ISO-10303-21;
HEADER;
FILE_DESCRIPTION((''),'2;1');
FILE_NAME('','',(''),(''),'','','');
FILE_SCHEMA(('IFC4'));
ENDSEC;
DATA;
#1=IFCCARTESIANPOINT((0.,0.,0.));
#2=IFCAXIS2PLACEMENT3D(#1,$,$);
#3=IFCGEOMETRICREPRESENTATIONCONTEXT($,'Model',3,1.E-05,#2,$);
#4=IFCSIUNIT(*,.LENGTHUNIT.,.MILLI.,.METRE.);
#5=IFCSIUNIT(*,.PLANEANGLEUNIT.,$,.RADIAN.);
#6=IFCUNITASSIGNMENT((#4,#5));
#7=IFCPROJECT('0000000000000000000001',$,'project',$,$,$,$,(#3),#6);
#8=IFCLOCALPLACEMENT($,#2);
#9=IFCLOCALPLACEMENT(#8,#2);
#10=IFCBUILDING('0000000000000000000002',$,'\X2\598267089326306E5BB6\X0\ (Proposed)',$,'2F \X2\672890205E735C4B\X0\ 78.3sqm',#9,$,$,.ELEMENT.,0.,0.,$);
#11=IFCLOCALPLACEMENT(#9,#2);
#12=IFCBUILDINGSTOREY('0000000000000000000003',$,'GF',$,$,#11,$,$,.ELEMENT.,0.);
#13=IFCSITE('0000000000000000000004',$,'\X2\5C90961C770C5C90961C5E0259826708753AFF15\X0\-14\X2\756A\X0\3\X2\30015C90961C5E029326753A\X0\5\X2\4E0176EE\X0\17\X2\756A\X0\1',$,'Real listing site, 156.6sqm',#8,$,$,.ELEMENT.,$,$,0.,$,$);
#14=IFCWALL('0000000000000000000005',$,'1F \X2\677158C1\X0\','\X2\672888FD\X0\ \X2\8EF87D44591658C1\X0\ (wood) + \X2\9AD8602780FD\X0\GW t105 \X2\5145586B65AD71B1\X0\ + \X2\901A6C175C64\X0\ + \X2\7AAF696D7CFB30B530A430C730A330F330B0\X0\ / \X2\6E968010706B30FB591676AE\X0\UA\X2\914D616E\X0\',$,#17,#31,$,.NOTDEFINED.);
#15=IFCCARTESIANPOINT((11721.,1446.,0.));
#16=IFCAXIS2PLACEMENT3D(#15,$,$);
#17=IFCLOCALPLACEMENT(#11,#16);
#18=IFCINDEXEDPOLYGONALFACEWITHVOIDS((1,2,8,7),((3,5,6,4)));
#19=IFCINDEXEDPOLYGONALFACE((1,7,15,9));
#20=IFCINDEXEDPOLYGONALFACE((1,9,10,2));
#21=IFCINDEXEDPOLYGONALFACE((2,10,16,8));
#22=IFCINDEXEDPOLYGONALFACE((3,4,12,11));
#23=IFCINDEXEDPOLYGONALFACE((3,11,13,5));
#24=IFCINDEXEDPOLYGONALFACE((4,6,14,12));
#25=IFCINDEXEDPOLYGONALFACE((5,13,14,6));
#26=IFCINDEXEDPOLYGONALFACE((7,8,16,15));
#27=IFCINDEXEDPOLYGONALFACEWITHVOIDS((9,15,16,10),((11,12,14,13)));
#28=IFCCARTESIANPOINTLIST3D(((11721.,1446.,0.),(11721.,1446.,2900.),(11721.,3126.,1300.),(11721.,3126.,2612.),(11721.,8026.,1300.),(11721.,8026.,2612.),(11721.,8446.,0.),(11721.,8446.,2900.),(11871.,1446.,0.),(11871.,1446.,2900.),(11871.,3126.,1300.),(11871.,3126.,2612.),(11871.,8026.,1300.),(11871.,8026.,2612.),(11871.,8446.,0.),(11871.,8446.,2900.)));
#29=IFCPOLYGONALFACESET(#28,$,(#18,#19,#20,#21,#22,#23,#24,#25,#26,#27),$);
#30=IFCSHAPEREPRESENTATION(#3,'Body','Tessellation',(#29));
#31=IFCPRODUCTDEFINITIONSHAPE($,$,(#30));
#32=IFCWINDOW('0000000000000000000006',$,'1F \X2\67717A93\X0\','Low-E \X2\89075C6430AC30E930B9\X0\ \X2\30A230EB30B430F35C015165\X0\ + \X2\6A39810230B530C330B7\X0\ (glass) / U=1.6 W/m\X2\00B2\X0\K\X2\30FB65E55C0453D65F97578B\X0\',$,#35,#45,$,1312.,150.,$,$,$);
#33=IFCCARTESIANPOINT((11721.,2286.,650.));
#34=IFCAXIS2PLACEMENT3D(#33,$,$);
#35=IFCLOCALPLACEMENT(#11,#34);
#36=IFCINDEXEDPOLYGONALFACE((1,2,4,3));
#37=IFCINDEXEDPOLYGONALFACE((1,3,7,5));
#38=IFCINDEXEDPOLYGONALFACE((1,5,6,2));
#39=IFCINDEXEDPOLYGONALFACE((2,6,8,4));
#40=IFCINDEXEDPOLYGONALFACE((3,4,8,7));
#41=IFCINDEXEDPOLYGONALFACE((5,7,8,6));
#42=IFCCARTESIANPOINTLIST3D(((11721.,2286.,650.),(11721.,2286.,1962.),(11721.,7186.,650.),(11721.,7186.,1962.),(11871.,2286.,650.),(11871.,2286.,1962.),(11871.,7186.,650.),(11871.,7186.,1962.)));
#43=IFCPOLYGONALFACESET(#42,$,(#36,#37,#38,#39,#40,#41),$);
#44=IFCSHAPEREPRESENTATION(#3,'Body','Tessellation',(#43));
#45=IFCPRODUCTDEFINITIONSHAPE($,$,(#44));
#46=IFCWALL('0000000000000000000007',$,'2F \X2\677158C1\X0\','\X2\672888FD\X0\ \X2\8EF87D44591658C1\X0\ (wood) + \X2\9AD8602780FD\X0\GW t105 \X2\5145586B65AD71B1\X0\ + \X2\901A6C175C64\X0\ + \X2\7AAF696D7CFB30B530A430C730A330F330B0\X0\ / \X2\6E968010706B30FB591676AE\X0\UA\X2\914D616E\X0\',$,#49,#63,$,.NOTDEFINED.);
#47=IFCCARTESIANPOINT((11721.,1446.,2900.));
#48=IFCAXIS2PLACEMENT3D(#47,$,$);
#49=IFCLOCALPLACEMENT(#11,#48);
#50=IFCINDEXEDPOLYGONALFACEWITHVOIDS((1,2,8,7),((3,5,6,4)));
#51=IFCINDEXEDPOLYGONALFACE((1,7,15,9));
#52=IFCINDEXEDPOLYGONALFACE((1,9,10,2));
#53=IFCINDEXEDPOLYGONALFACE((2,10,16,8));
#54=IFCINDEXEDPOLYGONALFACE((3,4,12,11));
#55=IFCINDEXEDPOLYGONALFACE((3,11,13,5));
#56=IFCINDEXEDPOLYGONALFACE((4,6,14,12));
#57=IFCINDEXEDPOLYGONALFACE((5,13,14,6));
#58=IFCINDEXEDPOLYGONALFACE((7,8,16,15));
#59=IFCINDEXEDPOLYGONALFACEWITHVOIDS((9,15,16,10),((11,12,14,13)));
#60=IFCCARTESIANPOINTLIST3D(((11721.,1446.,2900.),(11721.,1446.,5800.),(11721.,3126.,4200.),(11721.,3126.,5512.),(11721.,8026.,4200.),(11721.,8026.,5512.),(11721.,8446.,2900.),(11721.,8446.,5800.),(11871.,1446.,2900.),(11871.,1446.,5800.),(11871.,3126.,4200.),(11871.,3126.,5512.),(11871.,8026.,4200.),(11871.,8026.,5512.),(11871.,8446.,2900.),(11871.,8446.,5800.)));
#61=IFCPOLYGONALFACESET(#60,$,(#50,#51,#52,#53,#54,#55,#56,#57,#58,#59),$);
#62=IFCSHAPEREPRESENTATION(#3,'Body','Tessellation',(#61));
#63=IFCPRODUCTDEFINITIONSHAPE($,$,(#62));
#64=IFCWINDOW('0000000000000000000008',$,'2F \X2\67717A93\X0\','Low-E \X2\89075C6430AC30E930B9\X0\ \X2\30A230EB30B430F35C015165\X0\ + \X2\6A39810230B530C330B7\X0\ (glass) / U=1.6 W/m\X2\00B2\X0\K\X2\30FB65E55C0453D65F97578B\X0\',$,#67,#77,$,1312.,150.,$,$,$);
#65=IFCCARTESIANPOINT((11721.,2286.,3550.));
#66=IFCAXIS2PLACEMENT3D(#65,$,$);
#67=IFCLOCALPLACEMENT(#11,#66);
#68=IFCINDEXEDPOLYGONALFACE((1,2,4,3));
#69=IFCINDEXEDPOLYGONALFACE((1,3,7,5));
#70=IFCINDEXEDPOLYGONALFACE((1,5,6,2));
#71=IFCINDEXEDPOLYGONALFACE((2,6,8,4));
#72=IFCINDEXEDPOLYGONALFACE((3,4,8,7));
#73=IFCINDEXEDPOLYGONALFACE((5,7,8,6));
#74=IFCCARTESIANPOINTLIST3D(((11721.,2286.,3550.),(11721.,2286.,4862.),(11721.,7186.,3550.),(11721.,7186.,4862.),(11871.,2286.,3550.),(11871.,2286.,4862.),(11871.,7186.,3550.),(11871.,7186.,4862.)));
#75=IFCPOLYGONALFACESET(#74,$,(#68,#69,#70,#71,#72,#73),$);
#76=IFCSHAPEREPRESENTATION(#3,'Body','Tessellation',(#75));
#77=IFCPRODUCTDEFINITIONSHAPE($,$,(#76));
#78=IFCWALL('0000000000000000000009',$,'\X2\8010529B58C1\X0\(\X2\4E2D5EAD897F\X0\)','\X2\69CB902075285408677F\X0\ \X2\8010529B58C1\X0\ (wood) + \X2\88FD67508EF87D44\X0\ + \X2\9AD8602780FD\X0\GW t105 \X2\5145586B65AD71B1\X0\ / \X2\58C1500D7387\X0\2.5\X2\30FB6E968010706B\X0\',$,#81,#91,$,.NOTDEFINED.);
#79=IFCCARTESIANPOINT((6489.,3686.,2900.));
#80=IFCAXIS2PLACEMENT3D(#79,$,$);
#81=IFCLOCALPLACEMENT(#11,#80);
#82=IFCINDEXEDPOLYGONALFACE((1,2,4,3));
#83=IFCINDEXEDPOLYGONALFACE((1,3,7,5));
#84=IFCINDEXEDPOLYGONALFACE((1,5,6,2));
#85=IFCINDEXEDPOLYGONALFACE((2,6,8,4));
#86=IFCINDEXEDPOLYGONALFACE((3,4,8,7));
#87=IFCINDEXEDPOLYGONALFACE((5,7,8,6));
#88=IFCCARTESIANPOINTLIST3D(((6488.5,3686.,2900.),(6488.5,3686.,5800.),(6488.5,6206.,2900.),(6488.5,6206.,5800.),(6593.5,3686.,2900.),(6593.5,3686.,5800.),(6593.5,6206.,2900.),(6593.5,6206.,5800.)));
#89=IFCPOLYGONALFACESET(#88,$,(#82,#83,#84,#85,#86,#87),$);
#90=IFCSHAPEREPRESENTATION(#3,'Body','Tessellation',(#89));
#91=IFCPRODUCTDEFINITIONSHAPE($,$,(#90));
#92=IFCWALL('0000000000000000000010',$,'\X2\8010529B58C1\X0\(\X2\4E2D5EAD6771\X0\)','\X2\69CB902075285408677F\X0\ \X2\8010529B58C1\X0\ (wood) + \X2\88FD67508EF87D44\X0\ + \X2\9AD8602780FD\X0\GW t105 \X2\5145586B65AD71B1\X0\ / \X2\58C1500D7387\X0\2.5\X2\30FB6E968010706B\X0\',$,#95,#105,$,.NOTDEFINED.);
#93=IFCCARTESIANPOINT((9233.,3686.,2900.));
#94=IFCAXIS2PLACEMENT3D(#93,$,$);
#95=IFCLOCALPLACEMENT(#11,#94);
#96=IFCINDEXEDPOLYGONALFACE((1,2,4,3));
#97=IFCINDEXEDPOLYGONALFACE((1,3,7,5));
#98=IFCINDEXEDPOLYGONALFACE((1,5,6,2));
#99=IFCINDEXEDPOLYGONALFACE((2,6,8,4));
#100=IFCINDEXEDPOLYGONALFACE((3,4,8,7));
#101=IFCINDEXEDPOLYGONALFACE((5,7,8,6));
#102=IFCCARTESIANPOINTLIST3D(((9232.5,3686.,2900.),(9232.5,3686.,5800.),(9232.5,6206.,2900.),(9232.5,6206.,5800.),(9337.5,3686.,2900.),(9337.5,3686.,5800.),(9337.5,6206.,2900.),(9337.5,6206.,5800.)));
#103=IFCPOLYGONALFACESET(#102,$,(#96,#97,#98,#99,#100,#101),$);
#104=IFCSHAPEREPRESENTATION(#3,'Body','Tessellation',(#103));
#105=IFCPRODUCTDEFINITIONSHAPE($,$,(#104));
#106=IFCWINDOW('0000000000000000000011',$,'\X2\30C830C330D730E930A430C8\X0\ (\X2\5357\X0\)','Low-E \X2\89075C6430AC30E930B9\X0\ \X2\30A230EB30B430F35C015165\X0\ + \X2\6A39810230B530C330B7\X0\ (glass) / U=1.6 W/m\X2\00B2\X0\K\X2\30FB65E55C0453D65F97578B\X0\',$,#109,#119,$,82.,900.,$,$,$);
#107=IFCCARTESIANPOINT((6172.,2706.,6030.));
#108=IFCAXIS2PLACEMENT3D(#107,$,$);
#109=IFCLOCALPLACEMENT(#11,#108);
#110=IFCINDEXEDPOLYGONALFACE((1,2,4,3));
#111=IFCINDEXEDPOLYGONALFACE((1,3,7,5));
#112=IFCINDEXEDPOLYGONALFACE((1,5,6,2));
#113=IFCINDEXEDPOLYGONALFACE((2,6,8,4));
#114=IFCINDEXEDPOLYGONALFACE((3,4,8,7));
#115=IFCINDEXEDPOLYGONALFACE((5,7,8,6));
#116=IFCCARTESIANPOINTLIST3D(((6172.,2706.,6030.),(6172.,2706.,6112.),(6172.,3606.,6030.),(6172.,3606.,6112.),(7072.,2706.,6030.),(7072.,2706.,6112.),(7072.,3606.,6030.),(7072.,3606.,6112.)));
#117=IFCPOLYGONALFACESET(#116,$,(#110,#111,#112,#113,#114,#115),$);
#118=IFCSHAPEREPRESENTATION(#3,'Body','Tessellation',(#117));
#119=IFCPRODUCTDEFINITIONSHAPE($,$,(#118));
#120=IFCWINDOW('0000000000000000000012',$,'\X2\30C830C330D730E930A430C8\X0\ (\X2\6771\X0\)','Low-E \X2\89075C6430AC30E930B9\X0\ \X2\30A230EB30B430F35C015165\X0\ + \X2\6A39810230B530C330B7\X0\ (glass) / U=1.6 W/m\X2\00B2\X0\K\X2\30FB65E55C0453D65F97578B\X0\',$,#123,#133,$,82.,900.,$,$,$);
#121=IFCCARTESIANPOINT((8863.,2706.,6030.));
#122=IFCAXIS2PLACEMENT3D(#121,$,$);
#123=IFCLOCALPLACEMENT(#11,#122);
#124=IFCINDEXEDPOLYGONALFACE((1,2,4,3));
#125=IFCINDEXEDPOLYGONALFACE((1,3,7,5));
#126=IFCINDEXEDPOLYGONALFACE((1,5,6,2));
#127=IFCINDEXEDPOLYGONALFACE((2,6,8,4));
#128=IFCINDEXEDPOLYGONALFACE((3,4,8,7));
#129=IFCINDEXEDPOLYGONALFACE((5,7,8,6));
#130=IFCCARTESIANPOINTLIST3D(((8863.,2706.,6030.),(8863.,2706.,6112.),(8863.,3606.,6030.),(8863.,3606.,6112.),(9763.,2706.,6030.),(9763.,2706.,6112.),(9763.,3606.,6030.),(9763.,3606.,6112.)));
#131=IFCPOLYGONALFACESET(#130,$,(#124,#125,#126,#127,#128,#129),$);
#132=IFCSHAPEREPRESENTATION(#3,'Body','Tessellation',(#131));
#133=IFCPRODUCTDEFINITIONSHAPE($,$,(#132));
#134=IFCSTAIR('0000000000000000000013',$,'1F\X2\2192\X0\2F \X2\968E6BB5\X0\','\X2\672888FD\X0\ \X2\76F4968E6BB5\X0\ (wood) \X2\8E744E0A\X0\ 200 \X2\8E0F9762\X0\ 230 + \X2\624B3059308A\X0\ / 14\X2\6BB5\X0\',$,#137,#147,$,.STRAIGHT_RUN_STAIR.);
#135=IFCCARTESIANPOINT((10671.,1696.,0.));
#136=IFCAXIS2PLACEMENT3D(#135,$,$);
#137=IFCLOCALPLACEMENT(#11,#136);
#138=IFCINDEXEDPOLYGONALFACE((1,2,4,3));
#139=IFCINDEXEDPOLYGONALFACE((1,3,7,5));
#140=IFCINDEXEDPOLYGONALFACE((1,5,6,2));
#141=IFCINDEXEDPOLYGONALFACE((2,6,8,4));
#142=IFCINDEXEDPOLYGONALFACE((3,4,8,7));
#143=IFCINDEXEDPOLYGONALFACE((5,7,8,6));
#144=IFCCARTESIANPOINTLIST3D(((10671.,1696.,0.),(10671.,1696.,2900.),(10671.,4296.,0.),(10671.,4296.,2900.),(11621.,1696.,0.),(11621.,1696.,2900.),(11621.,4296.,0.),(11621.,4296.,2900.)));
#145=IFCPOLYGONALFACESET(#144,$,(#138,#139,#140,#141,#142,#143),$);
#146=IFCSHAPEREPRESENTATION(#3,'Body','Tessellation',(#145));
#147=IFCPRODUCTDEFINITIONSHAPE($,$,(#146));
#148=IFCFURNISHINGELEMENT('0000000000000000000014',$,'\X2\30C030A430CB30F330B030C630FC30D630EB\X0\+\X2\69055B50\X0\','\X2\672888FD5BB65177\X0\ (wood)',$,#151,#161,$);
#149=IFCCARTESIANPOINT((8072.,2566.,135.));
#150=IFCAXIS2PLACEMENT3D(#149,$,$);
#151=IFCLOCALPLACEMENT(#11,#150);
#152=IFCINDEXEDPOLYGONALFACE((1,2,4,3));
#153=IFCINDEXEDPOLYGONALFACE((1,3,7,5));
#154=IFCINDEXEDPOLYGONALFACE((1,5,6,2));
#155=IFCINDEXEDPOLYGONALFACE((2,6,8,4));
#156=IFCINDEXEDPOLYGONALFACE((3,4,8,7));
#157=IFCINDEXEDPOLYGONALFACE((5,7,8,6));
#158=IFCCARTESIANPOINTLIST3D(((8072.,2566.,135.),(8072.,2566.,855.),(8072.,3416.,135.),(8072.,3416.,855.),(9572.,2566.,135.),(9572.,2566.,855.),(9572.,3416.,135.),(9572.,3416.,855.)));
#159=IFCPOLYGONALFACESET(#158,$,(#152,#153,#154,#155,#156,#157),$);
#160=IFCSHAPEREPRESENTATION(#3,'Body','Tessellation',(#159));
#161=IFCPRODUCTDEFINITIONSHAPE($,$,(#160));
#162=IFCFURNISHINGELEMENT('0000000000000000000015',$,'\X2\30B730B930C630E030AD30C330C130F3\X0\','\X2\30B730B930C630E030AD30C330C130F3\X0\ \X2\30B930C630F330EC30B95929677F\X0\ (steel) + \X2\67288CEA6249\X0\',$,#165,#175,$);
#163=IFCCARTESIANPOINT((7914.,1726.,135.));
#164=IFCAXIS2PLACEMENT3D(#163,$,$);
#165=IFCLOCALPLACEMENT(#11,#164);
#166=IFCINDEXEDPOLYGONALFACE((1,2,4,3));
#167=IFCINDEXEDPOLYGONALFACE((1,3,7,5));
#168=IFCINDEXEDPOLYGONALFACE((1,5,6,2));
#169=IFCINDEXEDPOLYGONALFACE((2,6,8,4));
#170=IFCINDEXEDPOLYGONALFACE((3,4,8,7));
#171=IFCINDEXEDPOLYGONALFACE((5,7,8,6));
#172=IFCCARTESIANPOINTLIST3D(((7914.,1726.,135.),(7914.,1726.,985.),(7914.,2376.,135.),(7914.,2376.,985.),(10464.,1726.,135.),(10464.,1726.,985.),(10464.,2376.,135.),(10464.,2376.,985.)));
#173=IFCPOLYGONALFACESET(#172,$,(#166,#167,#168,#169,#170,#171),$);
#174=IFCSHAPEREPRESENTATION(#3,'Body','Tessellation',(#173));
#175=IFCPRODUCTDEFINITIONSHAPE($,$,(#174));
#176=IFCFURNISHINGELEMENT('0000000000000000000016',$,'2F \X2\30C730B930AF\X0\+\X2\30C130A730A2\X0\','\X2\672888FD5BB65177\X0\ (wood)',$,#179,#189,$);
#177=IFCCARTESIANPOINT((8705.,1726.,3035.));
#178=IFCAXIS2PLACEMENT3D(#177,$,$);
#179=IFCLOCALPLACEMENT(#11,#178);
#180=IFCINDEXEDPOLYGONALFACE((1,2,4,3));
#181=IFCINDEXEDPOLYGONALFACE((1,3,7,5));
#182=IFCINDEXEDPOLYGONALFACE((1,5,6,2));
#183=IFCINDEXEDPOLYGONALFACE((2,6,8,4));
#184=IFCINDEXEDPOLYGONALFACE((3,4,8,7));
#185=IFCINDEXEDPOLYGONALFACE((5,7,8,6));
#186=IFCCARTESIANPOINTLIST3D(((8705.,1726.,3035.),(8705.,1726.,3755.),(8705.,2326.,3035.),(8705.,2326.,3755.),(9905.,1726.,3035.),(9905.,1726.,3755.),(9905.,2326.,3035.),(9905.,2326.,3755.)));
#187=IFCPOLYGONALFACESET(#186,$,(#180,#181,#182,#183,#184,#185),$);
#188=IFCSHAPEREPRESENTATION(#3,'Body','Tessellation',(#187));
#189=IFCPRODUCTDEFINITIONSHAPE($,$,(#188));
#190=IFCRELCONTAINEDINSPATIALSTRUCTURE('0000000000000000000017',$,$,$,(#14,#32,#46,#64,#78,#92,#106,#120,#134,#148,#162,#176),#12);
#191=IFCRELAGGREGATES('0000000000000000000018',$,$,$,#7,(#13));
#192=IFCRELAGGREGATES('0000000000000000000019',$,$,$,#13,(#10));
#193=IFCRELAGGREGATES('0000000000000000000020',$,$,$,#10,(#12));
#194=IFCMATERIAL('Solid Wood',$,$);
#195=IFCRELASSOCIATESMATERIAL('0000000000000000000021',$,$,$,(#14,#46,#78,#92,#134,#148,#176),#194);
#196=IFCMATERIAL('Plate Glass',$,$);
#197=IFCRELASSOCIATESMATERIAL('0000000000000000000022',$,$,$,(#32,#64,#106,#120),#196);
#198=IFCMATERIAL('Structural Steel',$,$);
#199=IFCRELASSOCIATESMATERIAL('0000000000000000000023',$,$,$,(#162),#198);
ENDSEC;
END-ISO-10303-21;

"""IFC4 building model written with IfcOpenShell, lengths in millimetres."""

from ifc_helpers import new_model, si_unit, frame, frame_2d, origin, place, context, project, spatial, rectangle, extrude, material, element, fill, save


model = new_model("IFC4")

# Units and contexts
model_context = context("Model", 3, precision=1e-05, world=origin())
ifc_project = project(units=[si_unit("LENGTHUNIT", "METRE", prefix="MILLI"), si_unit("PLANEANGLEUNIT", "RADIAN")], contexts=[model_context])

# Site, building, storey
site_placement = place(None, origin())
site = spatial("IfcSite", under=ifc_project, at=site_placement, Name="岐阜県岐阜市如月町５-14番3、岐阜市錦町5丁目17番1", ObjectType="Real listing site, 156.6sqm", CompositionType="ELEMENT", RefElevation=0.0)
building_placement = place(site_placement, origin())
building = spatial("IfcBuilding", under=site, at=building_placement, Name="如月錦の家 (Proposed)", ObjectType="2F 木造平屋 78.3sqm", CompositionType="ELEMENT", ElevationOfRefHeight=0.0, ElevationOfTerrain=0.0)
storey_placement = place(building_placement, origin())
storey = spatial("IfcBuildingStorey", under=building, at=storey_placement, Name="GF", CompositionType="ELEMENT", Elevation=0.0)

# Shared definitions
ifc_material_1 = material(Name="Solid Wood")

# Wall, opening, window
wall_1_placement = place(storey_placement, frame((11721.0, 1446.0, 0.0)))
wall_1 = element("IfcWall", 1, at=wall_1_placement, inside=storey, material=ifc_material_1, Name="1F 東壁", Description="木製 軸組外壁 (wood) + 高性能GW t105 充填断熱 + 通気層 + 窯業系サイディング / 準耐火・外皮UA配慮", PredefinedType="NOTDEFINED", context=model_context, shape_type="SweptSolid", body=[
    extrude(rectangle(XDim=150.0, YDim=7000.0, at=frame_2d((75.0, 3500.0))), frame((11721.0, 1446.0, 0.0)), (0.0, 0.0, 1.0), 2900.0),
])
opening_1_placement = place(storey_placement, frame((11721.0, 2286.0, 650.0)))
opening_1 = element("IfcOpeningElement", 2, at=opening_1_placement, cuts=wall_1, PredefinedType="NOTDEFINED", context=model_context, shape_type="SweptSolid", body=[
    extrude(rectangle(XDim=150.0, YDim=4900.0, at=frame_2d((75.0, 2450.0))), frame((11721.0, 2286.0, 650.0)), (0.0, 0.0, 1.0), 1312.0),
])
ifc_material_2 = material(Name="Plate Glass")
window_1_placement = place(storey_placement, frame((11721.0, 2286.0, 650.0)))
window_1 = element("IfcWindow", 3, at=window_1_placement, inside=storey, material=ifc_material_2, Name="1F 東窓", Description="Low-E 複層ガラス アルゴン封入 + 樹脂サッシ (glass) / U=1.6 W/m²K・日射取得型", OverallHeight=1312.0, OverallWidth=150.0, context=model_context, shape_type="SweptSolid", body=[
    extrude(rectangle(XDim=150.0, YDim=4900.0, at=frame_2d((75.0, 2450.0))), frame((11721.0, 2286.0, 650.0)), (0.0, 0.0, 1.0), 1312.0),
])
fill(opening_1, window_1)

# Wall, opening, window
wall_2_placement = place(storey_placement, frame((11721.0, 1446.0, 2900.0)))
wall_2 = element("IfcWall", 4, at=wall_2_placement, inside=storey, material=ifc_material_1, Name="2F 東壁", Description="木製 軸組外壁 (wood) + 高性能GW t105 充填断熱 + 通気層 + 窯業系サイディング / 準耐火・外皮UA配慮", PredefinedType="NOTDEFINED", context=model_context, shape_type="SweptSolid", body=[
    extrude(rectangle(XDim=150.0, YDim=7000.0, at=frame_2d((75.0, 3500.0))), frame((11721.0, 1446.0, 2900.0)), (0.0, 0.0, 1.0), 2900.0),
])
opening_2_placement = place(storey_placement, frame((11721.0, 2286.0, 3550.0)))
opening_2 = element("IfcOpeningElement", 5, at=opening_2_placement, cuts=wall_2, PredefinedType="NOTDEFINED", context=model_context, shape_type="SweptSolid", body=[
    extrude(rectangle(XDim=150.0, YDim=4900.0, at=frame_2d((75.0, 2450.0))), frame((11721.0, 2286.0, 3550.0)), (0.0, 0.0, 1.0), 1312.0),
])
window_2_placement = place(storey_placement, frame((11721.0, 2286.0, 3550.0)))
window_2 = element("IfcWindow", 6, at=window_2_placement, inside=storey, material=ifc_material_2, Name="2F 東窓", Description="Low-E 複層ガラス アルゴン封入 + 樹脂サッシ (glass) / U=1.6 W/m²K・日射取得型", OverallHeight=1312.0, OverallWidth=150.0, context=model_context, shape_type="SweptSolid", body=[
    extrude(rectangle(XDim=150.0, YDim=4900.0, at=frame_2d((75.0, 2450.0))), frame((11721.0, 2286.0, 3550.0)), (0.0, 0.0, 1.0), 1312.0),
])
fill(opening_2, window_2)

# Walls
wall_3_placement = place(storey_placement, frame((6489.0, 3686.0, 2900.0)))
element("IfcWall", 7, at=wall_3_placement, inside=storey, material=ifc_material_1, Name="耐力壁(中庭西)", Description="構造用合板 耐力壁 (wood) + 製材軸組 + 高性能GW t105 充填断熱 / 壁倍率2.5・準耐火", PredefinedType="NOTDEFINED", context=model_context, shape_type="SweptSolid", body=[
    extrude(rectangle(XDim=105.0, YDim=2520.0, at=frame_2d((52.0, 1260.0))), frame((6489.0, 3686.0, 2900.0)), (0.0, 0.0, 1.0), 2900.0),
])
wall_4_placement = place(storey_placement, frame((9233.0, 3686.0, 2900.0)))
element("IfcWall", 8, at=wall_4_placement, inside=storey, material=ifc_material_1, Name="耐力壁(中庭東)", Description="構造用合板 耐力壁 (wood) + 製材軸組 + 高性能GW t105 充填断熱 / 壁倍率2.5・準耐火", PredefinedType="NOTDEFINED", context=model_context, shape_type="SweptSolid", body=[
    extrude(rectangle(XDim=105.0, YDim=2520.0, at=frame_2d((52.0, 1260.0))), frame((9233.0, 3686.0, 2900.0)), (0.0, 0.0, 1.0), 2900.0),
])

# Windows
window_3_placement = place(storey_placement, frame((6172.0, 2706.0, 6030.0)))
element("IfcWindow", 9, at=window_3_placement, inside=storey, material=ifc_material_2, Name="トップライト (南)", Description="Low-E 複層ガラス アルゴン封入 + 樹脂サッシ (glass) / U=1.6 W/m²K・日射取得型", OverallHeight=82.0, OverallWidth=900.0, context=model_context, shape_type="SweptSolid", body=[
    extrude(rectangle(XDim=900.0, YDim=900.0, at=frame_2d((450.0, 450.0))), frame((6172.0, 2706.0, 6030.0)), (0.0, 0.0, 1.0), 82.0),
])
window_4_placement = place(storey_placement, frame((8863.0, 2706.0, 6030.0)))
element("IfcWindow", 10, at=window_4_placement, inside=storey, material=ifc_material_2, Name="トップライト (東)", Description="Low-E 複層ガラス アルゴン封入 + 樹脂サッシ (glass) / U=1.6 W/m²K・日射取得型", OverallHeight=82.0, OverallWidth=900.0, context=model_context, shape_type="SweptSolid", body=[
    extrude(rectangle(XDim=900.0, YDim=900.0, at=frame_2d((450.0, 450.0))), frame((8863.0, 2706.0, 6030.0)), (0.0, 0.0, 1.0), 82.0),
])

# Stair
stair_placement = place(storey_placement, frame((10671.0, 1696.0, 0.0)))
element("IfcStair", 11, at=stair_placement, inside=storey, material=ifc_material_1, Name="1F→2F 階段", Description="木製 直階段 (wood) 蹴上 200 踏面 230 + 手すり / 14段", PredefinedType="STRAIGHT_RUN_STAIR", context=model_context, shape_type="SweptSolid", body=[
    extrude(rectangle(XDim=950.0, YDim=2600.0, at=frame_2d((475.0, 1300.0))), frame((10671.0, 1696.0, 0.0)), (0.0, 0.0, 1.0), 2900.0),
])

# Furnishing elements
furnishing_1_placement = place(storey_placement, frame((8072.0, 2566.0, 135.0)))
element("IfcFurnishingElement", 12, at=furnishing_1_placement, inside=storey, material=ifc_material_1, Name="ダイニングテーブル+椅子", Description="木製家具 (wood)", context=model_context, shape_type="SweptSolid", body=[
    extrude(rectangle(XDim=1500.0, YDim=850.0, at=frame_2d((750.0, 425.0))), frame((8072.0, 2566.0, 135.0)), (0.0, 0.0, 1.0), 720.0),
])
ifc_material_3 = material(Name="Structural Steel")
furnishing_2_placement = place(storey_placement, frame((7914.0, 1726.0, 135.0)))
element("IfcFurnishingElement", 13, at=furnishing_2_placement, inside=storey, material=ifc_material_3, Name="システムキッチン", Description="システムキッチン ステンレス天板 (steel) + 木質扉", context=model_context, shape_type="SweptSolid", body=[
    extrude(rectangle(XDim=2550.0, YDim=650.0, at=frame_2d((1275.0, 325.0))), frame((7914.0, 1726.0, 135.0)), (0.0, 0.0, 1.0), 850.0),
])
furnishing_3_placement = place(storey_placement, frame((8705.0, 1726.0, 3035.0)))
element("IfcFurnishingElement", 14, at=furnishing_3_placement, inside=storey, material=ifc_material_1, Name="2F デスク+チェア", Description="木製家具 (wood)", context=model_context, shape_type="SweptSolid", body=[
    extrude(rectangle(XDim=1200.0, YDim=600.0, at=frame_2d((600.0, 300.0))), frame((8705.0, 1726.0, 3035.0)), (0.0, 0.0, 1.0), 720.0),
])

save(model, "model.ifc")
